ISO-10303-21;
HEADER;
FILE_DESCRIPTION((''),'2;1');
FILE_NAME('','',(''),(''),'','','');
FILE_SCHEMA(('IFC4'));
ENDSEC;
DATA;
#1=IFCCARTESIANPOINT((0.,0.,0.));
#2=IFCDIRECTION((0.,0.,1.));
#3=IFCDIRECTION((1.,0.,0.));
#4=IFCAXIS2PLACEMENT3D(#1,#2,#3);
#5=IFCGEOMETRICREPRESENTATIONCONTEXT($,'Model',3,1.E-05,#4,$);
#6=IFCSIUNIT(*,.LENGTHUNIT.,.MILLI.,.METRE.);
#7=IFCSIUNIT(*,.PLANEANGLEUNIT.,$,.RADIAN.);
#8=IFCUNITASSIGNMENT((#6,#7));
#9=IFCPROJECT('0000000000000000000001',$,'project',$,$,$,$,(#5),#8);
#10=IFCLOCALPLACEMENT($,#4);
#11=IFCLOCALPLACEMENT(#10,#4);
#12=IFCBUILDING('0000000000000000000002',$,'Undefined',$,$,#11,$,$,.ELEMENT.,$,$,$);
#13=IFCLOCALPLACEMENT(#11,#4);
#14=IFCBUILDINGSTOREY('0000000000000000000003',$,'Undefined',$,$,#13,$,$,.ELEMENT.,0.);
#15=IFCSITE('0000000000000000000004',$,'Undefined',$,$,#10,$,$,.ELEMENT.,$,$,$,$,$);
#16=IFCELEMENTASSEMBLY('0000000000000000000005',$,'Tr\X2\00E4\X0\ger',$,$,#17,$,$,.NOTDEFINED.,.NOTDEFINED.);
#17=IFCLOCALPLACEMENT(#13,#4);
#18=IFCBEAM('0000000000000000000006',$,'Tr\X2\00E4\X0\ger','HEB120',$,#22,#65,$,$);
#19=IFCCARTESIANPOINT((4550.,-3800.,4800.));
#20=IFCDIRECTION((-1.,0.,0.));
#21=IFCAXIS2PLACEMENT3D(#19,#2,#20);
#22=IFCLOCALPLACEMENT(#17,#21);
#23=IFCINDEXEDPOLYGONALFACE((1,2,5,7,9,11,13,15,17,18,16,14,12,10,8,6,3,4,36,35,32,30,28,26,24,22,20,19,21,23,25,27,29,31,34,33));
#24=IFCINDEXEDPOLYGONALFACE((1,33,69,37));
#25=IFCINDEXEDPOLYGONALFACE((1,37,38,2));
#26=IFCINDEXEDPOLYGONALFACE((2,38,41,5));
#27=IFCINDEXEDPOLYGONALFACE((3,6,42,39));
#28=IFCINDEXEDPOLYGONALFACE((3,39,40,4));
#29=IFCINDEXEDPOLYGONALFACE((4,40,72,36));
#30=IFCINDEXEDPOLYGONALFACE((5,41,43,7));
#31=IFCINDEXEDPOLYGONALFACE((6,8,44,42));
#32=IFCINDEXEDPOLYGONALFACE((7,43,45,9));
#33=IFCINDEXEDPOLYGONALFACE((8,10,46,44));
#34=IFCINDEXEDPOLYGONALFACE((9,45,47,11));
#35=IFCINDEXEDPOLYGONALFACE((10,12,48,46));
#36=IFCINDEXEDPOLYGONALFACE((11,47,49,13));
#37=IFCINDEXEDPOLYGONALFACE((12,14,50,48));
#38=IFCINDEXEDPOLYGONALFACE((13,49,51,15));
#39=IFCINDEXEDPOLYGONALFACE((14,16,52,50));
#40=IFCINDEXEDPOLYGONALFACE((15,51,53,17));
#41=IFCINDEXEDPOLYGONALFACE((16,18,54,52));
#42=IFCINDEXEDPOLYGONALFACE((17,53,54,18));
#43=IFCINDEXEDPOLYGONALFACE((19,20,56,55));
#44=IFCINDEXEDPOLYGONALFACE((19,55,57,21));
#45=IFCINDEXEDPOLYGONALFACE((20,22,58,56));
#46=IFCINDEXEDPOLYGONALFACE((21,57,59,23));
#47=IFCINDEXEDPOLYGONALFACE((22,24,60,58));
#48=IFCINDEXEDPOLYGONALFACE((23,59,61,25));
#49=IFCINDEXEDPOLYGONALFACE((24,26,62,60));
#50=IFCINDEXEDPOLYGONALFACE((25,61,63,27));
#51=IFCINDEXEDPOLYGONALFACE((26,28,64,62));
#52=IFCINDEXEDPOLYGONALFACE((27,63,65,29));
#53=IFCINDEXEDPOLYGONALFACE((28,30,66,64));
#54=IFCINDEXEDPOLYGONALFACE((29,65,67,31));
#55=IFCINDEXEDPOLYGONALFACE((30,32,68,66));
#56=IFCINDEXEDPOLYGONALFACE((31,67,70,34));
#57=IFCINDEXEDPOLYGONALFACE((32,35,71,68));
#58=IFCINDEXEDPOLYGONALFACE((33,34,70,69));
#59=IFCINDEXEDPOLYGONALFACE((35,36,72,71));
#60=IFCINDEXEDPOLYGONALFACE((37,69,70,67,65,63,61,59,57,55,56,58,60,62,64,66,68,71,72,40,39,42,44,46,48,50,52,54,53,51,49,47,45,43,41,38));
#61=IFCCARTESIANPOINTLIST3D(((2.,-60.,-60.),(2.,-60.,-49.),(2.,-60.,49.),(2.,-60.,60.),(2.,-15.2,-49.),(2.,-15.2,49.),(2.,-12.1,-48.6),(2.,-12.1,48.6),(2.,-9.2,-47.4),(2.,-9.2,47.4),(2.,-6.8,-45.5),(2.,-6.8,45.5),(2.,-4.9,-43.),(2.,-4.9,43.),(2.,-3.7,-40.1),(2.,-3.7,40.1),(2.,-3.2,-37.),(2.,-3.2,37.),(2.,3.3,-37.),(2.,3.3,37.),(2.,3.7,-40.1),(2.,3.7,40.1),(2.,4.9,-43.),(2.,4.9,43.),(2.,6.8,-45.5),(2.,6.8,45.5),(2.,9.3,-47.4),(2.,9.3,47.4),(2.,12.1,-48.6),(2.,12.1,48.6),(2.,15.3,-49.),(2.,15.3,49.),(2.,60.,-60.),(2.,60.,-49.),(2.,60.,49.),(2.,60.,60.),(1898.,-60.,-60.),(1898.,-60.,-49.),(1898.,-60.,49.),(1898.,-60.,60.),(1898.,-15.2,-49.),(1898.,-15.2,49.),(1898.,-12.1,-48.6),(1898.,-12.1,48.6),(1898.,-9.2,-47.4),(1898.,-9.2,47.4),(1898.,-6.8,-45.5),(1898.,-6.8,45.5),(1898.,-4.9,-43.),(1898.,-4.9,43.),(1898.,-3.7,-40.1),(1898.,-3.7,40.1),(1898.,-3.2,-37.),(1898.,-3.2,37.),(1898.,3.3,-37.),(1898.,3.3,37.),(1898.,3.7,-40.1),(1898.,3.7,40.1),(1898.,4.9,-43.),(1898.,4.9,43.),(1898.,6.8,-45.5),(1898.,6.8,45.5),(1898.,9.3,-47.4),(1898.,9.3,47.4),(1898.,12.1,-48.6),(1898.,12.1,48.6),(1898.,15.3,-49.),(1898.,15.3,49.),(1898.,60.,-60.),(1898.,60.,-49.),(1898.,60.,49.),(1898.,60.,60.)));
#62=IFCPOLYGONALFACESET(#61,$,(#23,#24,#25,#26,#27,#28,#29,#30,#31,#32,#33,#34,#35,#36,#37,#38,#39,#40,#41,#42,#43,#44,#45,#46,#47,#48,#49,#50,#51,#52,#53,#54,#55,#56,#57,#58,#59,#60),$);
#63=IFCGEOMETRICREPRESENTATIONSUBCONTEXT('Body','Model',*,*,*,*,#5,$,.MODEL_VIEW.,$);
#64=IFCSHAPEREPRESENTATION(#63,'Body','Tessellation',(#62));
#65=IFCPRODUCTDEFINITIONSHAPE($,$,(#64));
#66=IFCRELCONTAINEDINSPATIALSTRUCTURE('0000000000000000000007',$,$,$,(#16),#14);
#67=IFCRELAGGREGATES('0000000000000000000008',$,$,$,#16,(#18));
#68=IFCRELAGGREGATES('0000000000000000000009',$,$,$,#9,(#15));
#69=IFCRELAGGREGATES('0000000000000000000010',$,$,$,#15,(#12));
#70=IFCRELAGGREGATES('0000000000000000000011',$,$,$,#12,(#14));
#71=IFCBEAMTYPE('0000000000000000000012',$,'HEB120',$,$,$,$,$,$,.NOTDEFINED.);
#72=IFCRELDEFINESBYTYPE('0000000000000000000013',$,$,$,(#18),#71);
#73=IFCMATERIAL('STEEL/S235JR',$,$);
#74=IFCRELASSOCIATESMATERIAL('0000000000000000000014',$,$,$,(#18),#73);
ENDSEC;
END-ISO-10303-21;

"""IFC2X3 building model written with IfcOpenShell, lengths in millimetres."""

from ifc_helpers import new_model, si_unit, frame, origin_with_axes, origin_2d_with_axis, place, context, subcontext, project, spatial, i_section, extrude, clip, halfspace, material, type_object, element, aggregate, save


model = new_model("IFC2X3")

# Units and contexts
model_context = context("Model", 3, precision=1e-05, world=origin_with_axes())
body_context = subcontext(model_context, "Body", "Model", "MODEL_VIEW")
ifc_project = project(units=[si_unit("LENGTHUNIT", "METRE", prefix="MILLI"), si_unit("PLANEANGLEUNIT", "RADIAN")], contexts=[model_context])

# Site, building, storey
site_placement = place(None, origin_with_axes())
site = spatial("IfcSite", under=ifc_project, at=site_placement, Name="Undefined", CompositionType="ELEMENT")
building_placement = place(site_placement, origin_with_axes())
building = spatial("IfcBuilding", under=site, at=building_placement, Name="Undefined", CompositionType="ELEMENT")
storey_placement = place(building_placement, origin_with_axes())
storey = spatial("IfcBuildingStorey", under=building, at=storey_placement, Name="Undefined", CompositionType="ELEMENT", Elevation=0.0)

# Shared definitions
ifc_material_1 = material(Name="STEEL/S235JR")

# Element assembly, beam
beam_type_1 = type_object("IfcBeamType", Name="HEB120", PredefinedType="NOTDEFINED")
assembly_1_placement = place(storey_placement, origin_with_axes())
assembly_1 = element("IfcElementAssembly", 1, at=assembly_1_placement, inside=storey, Name="Träger", AssemblyPlace="NOTDEFINED", PredefinedType="NOTDEFINED")
beam_1_placement = place(assembly_1_placement, frame((4550.0, -3800.0, 4800.0), z_axis=(0.0, 0.0, 1.0), x_axis=(-1.0, 0.0, 0.0)))
beam_1 = element("IfcBeam", 2, at=beam_1_placement, type_object=beam_type_1, material=ifc_material_1, Name="Träger", Description="HEB120", context=body_context, shape_type="Clipping", body=[
    clip(clip(extrude(i_section(OverallWidth=120.0, OverallDepth=120.0, WebThickness=6.5, FlangeThickness=11.0, FilletRadius=12.0, at=origin_2d_with_axis()), frame((1910.0, 0.0, 0.0), z_axis=(-1.0, 0.0, 0.0), x_axis=(0.0, -1.0, 0.0)), (0.0, 0.0, 1.0), 1910.0), halfspace(frame((1898.0, 0.0, -60.0), z_axis=(-1.0, 0.0, 0.0), x_axis=(0.0, 1.0, 0.0)), True)), halfspace(frame((2.0, 0.0, -60.0), z_axis=(1.0, 0.0, 0.0), x_axis=(0.0, -1.0, 0.0)), True)),
])

aggregate(assembly_1, [beam_1])

save(model, "model.ifc")
